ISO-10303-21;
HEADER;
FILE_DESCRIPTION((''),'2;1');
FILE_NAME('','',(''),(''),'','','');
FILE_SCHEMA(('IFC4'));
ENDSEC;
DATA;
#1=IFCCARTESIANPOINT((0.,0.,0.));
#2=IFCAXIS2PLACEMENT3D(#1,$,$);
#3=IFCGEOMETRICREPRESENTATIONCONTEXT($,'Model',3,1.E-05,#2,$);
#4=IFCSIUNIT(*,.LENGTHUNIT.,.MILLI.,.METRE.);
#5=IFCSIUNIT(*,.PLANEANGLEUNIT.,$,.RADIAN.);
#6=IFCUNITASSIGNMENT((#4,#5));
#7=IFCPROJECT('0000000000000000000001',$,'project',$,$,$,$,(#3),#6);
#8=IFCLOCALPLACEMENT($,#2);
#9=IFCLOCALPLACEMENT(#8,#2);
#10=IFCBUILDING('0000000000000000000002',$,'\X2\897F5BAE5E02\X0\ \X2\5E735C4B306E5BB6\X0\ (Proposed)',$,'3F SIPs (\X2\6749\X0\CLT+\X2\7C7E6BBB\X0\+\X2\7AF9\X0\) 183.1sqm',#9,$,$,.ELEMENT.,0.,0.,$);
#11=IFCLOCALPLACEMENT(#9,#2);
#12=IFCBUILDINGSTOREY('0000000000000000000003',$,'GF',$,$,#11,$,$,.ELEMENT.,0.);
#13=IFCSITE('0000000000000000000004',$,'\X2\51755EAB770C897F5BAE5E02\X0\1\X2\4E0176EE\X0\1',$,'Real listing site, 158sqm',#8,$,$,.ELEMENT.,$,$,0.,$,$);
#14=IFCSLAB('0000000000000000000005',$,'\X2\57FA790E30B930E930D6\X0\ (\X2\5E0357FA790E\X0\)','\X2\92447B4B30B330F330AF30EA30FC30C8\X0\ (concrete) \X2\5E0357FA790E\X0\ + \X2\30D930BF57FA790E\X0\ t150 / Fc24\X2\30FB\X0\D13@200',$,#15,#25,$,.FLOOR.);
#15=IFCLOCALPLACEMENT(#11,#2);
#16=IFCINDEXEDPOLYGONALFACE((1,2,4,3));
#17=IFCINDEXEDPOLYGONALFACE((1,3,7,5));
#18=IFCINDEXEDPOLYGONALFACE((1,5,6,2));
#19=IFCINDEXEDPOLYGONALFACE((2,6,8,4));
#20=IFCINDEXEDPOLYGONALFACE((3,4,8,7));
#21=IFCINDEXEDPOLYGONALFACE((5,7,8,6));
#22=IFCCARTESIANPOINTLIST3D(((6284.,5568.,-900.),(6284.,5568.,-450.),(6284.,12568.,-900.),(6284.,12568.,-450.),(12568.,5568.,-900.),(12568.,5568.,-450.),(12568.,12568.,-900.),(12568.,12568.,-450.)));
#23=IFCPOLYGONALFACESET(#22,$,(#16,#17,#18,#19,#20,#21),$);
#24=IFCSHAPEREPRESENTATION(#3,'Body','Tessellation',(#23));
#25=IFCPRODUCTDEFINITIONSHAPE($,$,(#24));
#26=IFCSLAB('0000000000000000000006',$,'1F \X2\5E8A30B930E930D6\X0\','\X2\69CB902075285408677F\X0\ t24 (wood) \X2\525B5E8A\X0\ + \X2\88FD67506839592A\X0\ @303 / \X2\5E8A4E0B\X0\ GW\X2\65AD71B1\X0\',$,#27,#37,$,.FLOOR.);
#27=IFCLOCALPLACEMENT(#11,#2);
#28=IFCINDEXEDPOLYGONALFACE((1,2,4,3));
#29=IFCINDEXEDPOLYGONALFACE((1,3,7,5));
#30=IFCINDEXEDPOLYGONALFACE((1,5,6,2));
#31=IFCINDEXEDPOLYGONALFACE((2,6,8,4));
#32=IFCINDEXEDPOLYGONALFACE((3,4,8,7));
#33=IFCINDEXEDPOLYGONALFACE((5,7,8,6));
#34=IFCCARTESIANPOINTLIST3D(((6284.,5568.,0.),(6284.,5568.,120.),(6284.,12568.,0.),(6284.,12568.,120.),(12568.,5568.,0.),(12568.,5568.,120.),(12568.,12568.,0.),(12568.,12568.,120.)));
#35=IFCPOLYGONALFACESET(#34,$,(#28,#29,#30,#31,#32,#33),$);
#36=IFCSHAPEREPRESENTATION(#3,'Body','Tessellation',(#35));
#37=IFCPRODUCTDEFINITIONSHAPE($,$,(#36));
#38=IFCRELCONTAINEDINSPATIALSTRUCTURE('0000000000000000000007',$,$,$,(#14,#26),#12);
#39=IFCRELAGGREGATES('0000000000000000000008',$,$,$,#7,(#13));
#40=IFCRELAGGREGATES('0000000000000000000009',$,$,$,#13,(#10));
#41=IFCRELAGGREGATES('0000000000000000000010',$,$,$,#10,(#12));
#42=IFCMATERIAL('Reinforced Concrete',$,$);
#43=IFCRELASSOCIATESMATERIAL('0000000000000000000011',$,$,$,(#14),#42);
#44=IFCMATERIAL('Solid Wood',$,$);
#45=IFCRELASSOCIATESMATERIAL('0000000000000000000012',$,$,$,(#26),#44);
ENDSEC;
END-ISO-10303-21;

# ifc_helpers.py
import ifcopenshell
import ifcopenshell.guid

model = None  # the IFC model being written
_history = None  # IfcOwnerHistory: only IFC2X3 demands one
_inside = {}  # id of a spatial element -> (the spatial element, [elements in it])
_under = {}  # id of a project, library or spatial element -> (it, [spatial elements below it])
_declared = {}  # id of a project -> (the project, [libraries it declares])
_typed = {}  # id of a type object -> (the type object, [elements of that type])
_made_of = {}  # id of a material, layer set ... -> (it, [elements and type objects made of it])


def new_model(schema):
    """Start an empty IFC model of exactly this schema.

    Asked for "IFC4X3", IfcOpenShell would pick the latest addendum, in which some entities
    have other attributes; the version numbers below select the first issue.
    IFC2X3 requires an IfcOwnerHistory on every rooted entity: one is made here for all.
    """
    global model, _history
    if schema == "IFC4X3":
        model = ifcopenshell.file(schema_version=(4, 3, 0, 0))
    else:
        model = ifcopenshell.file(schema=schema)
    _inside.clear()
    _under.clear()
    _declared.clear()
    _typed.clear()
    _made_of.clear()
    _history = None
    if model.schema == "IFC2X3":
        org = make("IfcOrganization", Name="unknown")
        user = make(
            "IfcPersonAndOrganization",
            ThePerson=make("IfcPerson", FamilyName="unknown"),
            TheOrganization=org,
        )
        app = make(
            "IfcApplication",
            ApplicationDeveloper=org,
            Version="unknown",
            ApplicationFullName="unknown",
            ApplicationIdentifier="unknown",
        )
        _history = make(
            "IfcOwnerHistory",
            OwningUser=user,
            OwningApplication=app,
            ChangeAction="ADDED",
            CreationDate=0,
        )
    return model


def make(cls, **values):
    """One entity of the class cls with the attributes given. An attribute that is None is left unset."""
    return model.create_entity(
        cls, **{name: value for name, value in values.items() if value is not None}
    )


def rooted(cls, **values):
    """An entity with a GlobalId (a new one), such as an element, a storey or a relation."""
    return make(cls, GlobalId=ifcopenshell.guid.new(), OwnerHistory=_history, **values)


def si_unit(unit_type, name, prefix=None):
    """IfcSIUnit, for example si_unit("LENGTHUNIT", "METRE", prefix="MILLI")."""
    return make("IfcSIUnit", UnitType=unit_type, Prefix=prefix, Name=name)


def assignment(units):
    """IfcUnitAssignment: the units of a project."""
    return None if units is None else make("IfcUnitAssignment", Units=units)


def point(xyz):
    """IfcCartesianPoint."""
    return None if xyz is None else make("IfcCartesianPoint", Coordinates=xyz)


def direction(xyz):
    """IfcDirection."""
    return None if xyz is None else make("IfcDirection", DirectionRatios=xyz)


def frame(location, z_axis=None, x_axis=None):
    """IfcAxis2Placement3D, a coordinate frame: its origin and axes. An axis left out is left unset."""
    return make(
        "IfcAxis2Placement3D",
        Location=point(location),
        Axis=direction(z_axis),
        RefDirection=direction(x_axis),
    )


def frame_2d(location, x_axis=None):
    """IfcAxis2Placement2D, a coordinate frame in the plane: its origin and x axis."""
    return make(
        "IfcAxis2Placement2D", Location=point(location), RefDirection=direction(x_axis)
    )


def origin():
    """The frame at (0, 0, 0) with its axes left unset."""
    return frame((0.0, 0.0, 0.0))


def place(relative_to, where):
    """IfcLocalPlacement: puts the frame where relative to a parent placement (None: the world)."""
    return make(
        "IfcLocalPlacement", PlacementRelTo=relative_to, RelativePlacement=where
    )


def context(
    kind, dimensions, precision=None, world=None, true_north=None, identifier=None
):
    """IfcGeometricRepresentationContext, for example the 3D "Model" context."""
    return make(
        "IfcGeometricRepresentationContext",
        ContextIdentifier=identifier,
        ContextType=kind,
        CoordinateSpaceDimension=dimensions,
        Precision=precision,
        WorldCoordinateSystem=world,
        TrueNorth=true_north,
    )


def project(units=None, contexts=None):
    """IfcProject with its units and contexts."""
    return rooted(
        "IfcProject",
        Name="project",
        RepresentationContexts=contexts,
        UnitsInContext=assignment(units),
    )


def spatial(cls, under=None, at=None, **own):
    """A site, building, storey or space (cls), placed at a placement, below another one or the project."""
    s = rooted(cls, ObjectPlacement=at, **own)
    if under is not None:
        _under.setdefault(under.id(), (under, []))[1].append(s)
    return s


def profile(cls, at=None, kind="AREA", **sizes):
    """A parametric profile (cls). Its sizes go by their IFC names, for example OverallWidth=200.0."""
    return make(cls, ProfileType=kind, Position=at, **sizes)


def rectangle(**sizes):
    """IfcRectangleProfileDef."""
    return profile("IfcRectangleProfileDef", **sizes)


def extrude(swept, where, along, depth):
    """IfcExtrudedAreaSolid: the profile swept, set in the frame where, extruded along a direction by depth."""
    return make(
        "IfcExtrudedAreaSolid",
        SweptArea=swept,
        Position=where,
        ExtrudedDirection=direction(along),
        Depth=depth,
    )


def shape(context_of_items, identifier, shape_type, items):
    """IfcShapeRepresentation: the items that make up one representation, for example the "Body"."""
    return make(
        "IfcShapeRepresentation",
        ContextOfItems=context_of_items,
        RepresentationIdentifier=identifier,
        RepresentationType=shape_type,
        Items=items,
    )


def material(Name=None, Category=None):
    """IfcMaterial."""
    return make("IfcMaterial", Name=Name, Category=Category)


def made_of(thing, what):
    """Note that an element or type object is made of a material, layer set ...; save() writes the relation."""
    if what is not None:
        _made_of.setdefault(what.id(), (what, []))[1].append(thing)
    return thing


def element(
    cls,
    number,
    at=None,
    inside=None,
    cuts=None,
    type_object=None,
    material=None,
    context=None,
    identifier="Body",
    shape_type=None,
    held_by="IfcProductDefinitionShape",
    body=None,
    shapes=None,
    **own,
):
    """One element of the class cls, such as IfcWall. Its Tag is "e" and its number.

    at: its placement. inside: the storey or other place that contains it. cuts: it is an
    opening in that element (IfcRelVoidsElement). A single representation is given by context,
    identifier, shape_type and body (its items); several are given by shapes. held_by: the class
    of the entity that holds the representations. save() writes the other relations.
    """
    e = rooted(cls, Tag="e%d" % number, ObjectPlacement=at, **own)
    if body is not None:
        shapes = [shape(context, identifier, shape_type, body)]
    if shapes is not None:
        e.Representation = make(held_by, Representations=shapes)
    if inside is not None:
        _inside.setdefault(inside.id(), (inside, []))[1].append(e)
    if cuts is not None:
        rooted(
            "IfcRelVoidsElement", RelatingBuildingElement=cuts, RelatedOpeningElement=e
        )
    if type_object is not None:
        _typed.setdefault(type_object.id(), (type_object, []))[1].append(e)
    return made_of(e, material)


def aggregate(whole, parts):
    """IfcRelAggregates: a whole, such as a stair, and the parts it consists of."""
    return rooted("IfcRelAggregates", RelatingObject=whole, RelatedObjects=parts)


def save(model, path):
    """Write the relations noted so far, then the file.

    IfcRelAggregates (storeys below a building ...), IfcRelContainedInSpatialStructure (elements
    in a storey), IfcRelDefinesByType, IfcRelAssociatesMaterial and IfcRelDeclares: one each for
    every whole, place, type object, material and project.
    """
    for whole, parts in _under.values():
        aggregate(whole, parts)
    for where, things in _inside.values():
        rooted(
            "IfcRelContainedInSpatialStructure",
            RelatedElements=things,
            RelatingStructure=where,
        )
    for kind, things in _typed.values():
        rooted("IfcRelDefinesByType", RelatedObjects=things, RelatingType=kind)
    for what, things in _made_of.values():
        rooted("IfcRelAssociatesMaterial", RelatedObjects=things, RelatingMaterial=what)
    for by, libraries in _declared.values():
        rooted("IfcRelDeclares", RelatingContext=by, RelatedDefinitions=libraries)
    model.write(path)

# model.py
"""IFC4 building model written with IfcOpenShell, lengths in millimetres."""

from ifc_helpers import new_model, si_unit, frame, frame_2d, origin, place, context, project, spatial, rectangle, extrude, material, element, save


model = new_model("IFC4")

# Units and contexts
model_context = context("Model", 3, precision=1e-05, world=origin())
ifc_project = project(units=[si_unit("LENGTHUNIT", "METRE", prefix="MILLI"), si_unit("PLANEANGLEUNIT", "RADIAN")], contexts=[model_context])

# Site, building, storey
site_placement = place(None, origin())
site = spatial("IfcSite", under=ifc_project, at=site_placement, Name="兵庫県西宮市1丁目1", ObjectType="Real listing site, 158sqm", CompositionType="ELEMENT", RefElevation=0.0)
building_placement = place(site_placement, origin())
building = spatial("IfcBuilding", under=site, at=building_placement, Name="西宮市 平屋の家 (Proposed)", ObjectType="3F SIPs (杉CLT+籾殻+竹) 183.1sqm", CompositionType="ELEMENT", ElevationOfRefHeight=0.0, ElevationOfTerrain=0.0)
storey_placement = place(building_placement, origin())
storey = spatial("IfcBuildingStorey", under=building, at=storey_placement, Name="GF", CompositionType="ELEMENT", Elevation=0.0)

# Slabs
ifc_material_1 = material(Name="Reinforced Concrete")
slab_1_placement = place(storey_placement, frame((3142.0, 2784.0, -450.0)))
element("IfcSlab", 1, at=slab_1_placement, inside=storey, material=ifc_material_1, Name="基礎スラブ (布基礎)", Description="鉄筋コンクリート (concrete) 布基礎 + ベタ基礎 t150 / Fc24・D13@200", PredefinedType="FLOOR", context=model_context, shape_type="SweptSolid", body=[
    extrude(rectangle(XDim=6284.0, YDim=7000.0, at=frame_2d((3142.0, 3500.0))), frame((3142.0, 2784.0, -450.0)), (0.0, 0.0, 1.0), 450.0),
])
ifc_material_2 = material(Name="Solid Wood")
slab_2_placement = place(storey_placement, frame((3142.0, 2784.0, 0.0)))
element("IfcSlab", 2, at=slab_2_placement, inside=storey, material=ifc_material_2, Name="1F 床スラブ", Description="構造用合板 t24 (wood) 剛床 + 製材根太 @303 / 床下 GW断熱", PredefinedType="FLOOR", context=model_context, shape_type="SweptSolid", body=[
    extrude(rectangle(XDim=6284.0, YDim=7000.0, at=frame_2d((3142.0, 3500.0))), frame((3142.0, 2784.0, 0.0)), (0.0, 0.0, 1.0), 120.0),
])

save(model, "model.ifc")
